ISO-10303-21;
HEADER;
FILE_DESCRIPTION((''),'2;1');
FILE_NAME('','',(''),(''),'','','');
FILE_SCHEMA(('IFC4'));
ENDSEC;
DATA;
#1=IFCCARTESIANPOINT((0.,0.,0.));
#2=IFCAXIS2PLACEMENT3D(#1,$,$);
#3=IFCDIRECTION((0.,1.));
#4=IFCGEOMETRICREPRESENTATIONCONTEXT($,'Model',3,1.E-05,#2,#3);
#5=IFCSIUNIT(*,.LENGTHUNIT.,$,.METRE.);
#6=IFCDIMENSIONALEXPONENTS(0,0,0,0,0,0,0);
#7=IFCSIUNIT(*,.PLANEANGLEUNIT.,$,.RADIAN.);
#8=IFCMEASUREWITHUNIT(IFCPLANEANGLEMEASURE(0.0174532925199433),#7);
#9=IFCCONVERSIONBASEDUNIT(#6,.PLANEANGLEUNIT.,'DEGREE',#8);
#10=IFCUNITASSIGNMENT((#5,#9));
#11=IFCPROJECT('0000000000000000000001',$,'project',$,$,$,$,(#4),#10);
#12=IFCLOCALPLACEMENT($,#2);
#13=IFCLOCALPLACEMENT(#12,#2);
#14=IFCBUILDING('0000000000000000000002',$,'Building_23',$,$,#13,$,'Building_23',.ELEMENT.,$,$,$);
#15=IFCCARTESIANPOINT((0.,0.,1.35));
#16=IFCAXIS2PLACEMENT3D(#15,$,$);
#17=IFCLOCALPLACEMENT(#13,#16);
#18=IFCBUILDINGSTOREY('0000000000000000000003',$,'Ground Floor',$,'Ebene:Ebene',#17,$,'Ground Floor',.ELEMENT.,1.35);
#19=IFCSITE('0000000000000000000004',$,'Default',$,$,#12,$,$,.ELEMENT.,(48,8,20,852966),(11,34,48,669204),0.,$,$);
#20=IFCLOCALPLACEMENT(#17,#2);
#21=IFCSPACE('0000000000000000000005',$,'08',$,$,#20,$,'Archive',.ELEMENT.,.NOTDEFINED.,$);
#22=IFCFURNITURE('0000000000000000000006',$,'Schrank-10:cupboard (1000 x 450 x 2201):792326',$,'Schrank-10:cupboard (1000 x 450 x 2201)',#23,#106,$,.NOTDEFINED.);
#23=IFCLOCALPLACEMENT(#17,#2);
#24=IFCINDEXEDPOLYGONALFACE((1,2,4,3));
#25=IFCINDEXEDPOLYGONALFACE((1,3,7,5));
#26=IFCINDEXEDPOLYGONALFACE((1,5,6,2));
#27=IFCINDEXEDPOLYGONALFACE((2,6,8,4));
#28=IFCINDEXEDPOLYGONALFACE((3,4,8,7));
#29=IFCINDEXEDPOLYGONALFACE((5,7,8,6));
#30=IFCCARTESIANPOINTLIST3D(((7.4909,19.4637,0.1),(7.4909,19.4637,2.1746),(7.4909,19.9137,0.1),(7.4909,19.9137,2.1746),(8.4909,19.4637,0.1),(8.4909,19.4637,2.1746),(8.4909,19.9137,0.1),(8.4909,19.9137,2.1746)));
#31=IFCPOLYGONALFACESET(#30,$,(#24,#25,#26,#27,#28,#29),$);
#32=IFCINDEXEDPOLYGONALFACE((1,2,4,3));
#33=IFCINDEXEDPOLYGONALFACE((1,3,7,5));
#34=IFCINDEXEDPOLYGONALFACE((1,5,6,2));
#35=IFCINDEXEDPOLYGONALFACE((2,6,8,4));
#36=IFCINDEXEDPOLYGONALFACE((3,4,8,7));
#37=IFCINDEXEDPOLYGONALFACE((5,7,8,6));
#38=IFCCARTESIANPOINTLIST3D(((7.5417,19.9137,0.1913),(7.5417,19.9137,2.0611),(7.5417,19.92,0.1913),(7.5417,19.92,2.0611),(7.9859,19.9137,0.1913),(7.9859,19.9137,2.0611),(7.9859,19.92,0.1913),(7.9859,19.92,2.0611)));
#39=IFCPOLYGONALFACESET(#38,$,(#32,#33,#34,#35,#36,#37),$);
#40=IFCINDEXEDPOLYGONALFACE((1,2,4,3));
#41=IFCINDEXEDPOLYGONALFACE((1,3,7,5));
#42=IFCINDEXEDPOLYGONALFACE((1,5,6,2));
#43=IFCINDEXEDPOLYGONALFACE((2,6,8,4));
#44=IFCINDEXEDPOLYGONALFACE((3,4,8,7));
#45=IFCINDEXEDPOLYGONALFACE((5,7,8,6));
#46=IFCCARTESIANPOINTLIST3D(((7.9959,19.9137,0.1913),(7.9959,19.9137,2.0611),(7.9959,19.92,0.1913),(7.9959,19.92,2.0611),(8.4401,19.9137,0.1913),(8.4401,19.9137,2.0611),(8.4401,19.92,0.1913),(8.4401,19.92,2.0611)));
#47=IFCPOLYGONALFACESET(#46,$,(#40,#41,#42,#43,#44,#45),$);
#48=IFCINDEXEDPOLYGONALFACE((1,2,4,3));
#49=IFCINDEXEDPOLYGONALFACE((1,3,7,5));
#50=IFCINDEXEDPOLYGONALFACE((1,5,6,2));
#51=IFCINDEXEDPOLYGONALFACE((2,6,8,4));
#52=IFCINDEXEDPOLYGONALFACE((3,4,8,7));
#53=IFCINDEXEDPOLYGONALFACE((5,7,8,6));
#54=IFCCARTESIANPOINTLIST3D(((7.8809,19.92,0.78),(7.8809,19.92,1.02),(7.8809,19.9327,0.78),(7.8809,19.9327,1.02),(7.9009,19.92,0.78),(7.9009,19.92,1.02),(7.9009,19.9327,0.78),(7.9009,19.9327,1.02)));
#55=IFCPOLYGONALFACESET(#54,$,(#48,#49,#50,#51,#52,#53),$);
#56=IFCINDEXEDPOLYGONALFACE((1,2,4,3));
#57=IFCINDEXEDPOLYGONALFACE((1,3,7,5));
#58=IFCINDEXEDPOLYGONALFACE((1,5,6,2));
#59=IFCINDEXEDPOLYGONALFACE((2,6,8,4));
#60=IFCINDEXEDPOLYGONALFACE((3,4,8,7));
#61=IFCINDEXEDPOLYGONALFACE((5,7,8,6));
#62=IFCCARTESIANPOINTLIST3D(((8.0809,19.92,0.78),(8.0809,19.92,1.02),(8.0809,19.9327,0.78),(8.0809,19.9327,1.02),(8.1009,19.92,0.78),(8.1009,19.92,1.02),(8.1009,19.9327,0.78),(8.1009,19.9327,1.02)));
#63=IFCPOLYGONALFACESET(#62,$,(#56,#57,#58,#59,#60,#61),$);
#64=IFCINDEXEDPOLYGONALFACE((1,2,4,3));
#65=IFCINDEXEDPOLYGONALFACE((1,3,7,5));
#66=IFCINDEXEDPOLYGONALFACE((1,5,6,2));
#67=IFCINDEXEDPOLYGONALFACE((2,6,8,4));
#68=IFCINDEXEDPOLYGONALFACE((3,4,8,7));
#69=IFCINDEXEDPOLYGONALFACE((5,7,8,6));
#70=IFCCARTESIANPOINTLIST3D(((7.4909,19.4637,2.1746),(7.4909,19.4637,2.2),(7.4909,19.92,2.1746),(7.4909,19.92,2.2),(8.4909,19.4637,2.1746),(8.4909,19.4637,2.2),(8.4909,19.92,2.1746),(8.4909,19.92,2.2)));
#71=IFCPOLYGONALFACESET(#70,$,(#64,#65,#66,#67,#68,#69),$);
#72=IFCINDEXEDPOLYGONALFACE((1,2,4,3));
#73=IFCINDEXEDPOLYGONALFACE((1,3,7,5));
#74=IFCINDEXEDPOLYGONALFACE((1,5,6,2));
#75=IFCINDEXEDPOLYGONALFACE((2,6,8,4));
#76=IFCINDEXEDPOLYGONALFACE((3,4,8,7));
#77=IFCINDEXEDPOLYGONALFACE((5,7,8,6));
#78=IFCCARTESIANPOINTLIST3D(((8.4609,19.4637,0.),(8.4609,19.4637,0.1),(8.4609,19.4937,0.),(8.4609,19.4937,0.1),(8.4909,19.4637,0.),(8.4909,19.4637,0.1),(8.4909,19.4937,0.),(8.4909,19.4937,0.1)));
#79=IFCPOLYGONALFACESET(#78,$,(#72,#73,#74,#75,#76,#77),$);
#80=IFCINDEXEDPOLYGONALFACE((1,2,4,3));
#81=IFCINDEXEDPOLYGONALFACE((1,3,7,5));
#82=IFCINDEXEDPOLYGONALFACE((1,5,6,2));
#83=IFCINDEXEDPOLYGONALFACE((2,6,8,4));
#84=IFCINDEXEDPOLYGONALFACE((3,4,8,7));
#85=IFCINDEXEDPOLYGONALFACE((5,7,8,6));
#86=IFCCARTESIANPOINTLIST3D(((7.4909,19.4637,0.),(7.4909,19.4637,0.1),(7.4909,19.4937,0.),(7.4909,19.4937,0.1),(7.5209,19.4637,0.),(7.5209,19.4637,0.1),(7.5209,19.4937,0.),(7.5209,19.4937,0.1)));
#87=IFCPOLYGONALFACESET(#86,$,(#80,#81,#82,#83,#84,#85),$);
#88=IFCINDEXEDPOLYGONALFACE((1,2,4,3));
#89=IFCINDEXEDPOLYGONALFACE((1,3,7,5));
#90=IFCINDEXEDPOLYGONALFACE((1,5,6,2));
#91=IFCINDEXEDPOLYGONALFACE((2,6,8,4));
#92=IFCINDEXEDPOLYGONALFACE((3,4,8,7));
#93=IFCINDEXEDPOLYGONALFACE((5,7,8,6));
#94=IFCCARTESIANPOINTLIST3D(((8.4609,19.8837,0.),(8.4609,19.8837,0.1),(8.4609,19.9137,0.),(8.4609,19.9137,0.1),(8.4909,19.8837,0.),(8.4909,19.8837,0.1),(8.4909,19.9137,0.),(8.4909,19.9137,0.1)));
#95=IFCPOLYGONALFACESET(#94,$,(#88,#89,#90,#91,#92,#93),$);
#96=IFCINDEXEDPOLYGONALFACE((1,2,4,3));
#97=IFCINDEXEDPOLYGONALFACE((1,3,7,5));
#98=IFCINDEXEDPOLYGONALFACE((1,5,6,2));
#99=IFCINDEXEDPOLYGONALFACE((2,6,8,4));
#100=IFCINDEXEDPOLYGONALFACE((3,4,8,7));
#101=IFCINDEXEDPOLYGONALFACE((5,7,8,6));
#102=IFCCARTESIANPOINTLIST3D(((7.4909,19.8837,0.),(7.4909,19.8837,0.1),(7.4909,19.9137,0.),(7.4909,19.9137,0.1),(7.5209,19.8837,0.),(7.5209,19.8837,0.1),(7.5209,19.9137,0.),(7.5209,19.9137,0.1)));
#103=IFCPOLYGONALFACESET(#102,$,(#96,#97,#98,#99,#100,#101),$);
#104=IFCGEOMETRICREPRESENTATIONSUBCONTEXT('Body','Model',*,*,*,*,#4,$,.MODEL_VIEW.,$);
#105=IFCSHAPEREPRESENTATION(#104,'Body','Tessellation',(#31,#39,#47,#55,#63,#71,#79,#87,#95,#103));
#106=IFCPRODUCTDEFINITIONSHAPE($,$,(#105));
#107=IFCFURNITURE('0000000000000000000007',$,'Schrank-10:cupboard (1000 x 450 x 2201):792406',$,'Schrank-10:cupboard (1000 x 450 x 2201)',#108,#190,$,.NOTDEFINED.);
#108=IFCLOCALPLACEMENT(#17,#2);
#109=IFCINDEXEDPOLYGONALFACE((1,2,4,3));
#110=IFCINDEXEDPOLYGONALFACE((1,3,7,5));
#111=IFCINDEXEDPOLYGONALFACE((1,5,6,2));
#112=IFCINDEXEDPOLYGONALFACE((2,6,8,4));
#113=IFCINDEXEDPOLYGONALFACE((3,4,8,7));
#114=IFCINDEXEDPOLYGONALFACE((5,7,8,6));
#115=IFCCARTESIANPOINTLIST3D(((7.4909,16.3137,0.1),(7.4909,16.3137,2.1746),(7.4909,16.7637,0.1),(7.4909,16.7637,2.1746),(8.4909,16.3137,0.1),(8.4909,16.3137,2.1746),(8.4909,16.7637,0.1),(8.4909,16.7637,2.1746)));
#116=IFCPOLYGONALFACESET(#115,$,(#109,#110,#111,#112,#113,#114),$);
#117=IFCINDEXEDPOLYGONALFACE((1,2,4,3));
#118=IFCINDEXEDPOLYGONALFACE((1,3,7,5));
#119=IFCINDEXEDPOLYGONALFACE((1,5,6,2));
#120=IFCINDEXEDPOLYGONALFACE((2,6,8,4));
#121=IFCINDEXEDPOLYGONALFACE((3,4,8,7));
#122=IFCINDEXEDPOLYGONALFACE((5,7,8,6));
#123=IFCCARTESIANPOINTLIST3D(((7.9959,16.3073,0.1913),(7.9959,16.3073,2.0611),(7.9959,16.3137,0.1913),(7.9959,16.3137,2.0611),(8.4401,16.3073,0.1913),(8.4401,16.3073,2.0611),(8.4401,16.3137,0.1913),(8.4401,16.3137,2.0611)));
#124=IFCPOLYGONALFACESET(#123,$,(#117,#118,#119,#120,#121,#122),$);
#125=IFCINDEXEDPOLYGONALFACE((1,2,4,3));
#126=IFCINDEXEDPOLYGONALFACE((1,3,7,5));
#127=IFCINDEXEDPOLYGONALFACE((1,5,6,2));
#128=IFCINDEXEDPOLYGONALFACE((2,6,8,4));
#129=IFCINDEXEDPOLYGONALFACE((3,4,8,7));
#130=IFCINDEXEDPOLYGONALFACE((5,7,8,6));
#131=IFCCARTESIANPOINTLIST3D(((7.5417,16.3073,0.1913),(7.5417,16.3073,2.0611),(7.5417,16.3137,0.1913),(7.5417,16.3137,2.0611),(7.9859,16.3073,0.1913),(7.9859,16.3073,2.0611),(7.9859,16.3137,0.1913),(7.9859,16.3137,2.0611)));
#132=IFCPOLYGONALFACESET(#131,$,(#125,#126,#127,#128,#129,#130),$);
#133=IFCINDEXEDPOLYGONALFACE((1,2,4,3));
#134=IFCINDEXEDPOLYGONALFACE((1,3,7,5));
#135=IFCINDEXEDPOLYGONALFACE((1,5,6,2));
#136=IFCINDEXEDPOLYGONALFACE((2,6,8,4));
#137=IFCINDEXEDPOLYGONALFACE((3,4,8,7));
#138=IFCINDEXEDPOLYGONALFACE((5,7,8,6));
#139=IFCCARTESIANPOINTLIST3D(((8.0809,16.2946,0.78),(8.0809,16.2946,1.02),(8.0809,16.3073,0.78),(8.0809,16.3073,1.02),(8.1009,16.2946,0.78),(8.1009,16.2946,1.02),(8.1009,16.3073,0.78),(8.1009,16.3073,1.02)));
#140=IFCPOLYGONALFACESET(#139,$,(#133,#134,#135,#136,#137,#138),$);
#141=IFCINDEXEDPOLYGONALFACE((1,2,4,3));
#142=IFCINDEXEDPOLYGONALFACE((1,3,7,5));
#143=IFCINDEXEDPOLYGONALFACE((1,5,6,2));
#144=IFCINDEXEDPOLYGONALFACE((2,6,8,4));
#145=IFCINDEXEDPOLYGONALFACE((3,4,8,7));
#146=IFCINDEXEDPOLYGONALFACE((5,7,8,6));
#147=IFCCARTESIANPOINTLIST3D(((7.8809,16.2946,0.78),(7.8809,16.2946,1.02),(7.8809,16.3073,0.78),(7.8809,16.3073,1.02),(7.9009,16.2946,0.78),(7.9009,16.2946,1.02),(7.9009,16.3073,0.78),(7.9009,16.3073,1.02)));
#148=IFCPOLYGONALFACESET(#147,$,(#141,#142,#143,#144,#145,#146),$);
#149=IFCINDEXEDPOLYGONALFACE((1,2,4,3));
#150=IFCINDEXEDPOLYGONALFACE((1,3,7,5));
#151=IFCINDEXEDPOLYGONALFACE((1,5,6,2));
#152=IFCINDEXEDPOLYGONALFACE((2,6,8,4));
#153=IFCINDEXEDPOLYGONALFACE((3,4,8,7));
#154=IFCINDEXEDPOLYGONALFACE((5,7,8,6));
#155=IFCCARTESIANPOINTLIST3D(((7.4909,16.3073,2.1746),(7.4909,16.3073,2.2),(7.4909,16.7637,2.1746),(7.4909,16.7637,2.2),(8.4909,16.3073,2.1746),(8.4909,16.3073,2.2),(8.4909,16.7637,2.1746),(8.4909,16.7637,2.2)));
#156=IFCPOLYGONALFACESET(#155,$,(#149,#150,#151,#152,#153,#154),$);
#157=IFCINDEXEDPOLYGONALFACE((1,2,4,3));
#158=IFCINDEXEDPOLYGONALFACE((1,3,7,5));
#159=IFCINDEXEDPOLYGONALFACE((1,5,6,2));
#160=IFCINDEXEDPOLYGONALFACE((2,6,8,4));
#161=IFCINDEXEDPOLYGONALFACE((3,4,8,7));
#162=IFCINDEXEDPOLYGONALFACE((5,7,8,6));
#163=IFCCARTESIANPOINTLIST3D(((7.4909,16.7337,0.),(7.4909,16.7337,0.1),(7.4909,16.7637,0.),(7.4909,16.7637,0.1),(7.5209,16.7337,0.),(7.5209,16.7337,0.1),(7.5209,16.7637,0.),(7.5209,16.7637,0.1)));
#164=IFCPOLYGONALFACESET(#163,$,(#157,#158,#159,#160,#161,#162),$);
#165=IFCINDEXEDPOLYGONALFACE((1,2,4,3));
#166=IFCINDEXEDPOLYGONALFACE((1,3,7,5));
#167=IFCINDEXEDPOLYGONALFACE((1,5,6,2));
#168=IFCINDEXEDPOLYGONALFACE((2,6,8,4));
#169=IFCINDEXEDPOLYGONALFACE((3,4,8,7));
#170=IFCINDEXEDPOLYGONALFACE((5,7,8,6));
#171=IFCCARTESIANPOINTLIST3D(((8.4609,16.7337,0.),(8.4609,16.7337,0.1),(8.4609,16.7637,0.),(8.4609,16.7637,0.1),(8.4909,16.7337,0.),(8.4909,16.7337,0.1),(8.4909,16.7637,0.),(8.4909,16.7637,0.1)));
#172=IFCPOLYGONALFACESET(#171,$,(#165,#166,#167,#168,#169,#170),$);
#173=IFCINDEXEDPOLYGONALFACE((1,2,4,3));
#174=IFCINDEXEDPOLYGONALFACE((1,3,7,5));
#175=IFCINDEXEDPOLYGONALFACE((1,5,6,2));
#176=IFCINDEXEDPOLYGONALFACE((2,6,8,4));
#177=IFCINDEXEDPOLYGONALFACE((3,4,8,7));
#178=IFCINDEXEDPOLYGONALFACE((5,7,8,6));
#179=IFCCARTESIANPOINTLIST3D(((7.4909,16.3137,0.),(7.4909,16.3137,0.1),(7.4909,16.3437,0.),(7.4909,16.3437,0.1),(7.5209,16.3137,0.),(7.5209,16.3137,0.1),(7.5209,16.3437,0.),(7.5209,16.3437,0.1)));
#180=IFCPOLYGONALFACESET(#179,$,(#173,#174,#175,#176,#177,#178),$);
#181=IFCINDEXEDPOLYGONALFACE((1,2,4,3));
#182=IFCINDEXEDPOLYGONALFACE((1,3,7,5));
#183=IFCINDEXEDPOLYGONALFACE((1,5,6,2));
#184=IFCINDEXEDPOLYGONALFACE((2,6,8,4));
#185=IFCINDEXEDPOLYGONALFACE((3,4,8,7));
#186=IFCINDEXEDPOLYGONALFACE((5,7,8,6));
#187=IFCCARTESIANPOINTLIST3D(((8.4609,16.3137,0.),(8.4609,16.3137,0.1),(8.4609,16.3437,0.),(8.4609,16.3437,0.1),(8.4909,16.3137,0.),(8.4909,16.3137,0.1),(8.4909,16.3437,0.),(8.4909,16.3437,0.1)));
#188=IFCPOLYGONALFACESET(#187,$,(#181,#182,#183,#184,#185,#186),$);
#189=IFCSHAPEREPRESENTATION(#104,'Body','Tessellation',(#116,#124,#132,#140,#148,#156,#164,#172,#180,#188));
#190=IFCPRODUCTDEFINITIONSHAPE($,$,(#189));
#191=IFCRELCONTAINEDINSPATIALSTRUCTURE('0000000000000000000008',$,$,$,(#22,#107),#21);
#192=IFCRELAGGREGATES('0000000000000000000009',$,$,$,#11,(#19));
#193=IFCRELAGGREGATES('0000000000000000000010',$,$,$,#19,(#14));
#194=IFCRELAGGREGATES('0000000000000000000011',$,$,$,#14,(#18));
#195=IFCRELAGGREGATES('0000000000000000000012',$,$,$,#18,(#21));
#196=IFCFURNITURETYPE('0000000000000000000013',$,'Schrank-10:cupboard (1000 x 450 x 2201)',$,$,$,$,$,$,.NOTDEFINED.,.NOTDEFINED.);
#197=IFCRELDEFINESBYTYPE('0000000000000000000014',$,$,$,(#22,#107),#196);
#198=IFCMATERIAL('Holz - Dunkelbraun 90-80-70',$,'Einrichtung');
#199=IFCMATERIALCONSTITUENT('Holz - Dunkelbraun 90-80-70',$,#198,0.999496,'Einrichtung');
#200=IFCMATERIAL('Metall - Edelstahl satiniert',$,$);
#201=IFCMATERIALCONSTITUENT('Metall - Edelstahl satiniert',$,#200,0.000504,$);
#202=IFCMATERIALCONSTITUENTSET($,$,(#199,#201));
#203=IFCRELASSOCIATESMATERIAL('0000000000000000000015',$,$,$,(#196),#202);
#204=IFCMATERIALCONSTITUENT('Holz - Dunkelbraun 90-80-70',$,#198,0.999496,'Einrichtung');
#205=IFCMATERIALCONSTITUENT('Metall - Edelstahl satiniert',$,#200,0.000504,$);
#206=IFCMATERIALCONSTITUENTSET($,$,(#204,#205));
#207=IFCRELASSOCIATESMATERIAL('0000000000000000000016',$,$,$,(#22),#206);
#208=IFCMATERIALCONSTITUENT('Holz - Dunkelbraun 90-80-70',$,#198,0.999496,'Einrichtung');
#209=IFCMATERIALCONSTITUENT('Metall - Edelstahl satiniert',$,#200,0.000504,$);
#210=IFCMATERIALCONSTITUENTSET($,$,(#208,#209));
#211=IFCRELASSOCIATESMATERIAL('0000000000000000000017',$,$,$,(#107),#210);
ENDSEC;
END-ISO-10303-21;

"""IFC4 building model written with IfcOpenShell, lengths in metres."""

from ifc_helpers import new_model, entity, si_unit, converted_unit, direction, frame, origin, place, context, subcontext, project, spatial, indexed_curve, outline, extrude, source, transform, mapped, material, constituent, constituent_set, type_object, type_shapes, element, save


model = new_model("IFC4")

# Units and contexts
model_context = context("Model", 3, precision=1e-05, world=origin(), true_north=direction((0.0, 1.0)))
body_context = subcontext(model_context, "Body", "Model", "MODEL_VIEW")
ifc_project = project(units=[si_unit("LENGTHUNIT", "METRE"), converted_unit("PLANEANGLEUNIT", "DEGREE", entity("IfcPlaneAngleMeasure", 0.0174532925199433), si_unit("PLANEANGLEUNIT", "RADIAN"), dimensions=[0, 0, 0, 0, 0, 0, 0])], contexts=[model_context])

# Site, building, storey
site_placement = place(None, origin())
site = spatial("IfcSite", under=ifc_project, at=site_placement, Name="Default", CompositionType="ELEMENT", RefLatitude=(48, 8, 20, 852966), RefLongitude=(11, 34, 48, 669204), RefElevation=0.0)
building_placement = place(site_placement, origin())
building = spatial("IfcBuilding", under=site, at=building_placement, Name="Building_23", LongName="Building_23", CompositionType="ELEMENT")
storey_placement = place(building_placement, frame((0.0, 0.0, 1.35)))
storey = spatial("IfcBuildingStorey", under=building, at=storey_placement, Name="Ground Floor", ObjectType="Ebene:Ebene", LongName="Ground Floor", CompositionType="ELEMENT", Elevation=1.35)

# Shared definitions
space_placement = place(storey_placement, origin())
space = spatial("IfcSpace", under=storey, at=space_placement, Name="08", LongName="Archive", CompositionType="ELEMENT", PredefinedType="NOTDEFINED")

# Furniture
ifc_material_1 = material(Name="Holz - Dunkelbraun 90-80-70", Category="Einrichtung")
ifc_material_2 = material(Name="Metall - Edelstahl satiniert")
ifc_constituent_1 = constituent(ifc_material_1, Name="Holz - Dunkelbraun 90-80-70", Category="Einrichtung", fraction=0.999496)
ifc_constituent_2 = constituent(ifc_material_2, Name="Metall - Edelstahl satiniert", fraction=0.000504)
ifc_constituent_set_1 = constituent_set(constituents=[ifc_constituent_1, ifc_constituent_2])
furniture_type = type_object("IfcFurnitureType", Name="Schrank-10:cupboard (1000 x 450 x 2201)", AssemblyPlace="NOTDEFINED", PredefinedType="NOTDEFINED", material=ifc_constituent_set_1)
shared_shape_1 = source(origin(), body_context, "Body", "SweptSolid", [
    extrude(outline(indexed_curve([(-0.225, -0.5), (0.225, -0.5), (0.225, 0.5), (-0.225, 0.5), (-0.225, -0.5)], self_intersect=False)), frame((-0.2692, -0.3632, 0.1), z_axis=(0.0, 0.0, 1.0), x_axis=(0.0, 1.0, 0.0)), (0.0, 0.0, 1.0), 2.0746),
    extrude(outline(indexed_curve([(-0.0032, -0.2221), (0.0032, -0.2221), (0.0032, 0.2221), (-0.0032, 0.2221), (-0.0032, -0.2221)], self_intersect=False)), frame((-0.0421, -0.5913, 0.1913), z_axis=(0.0, 0.0, 1.0), x_axis=(0.0, 1.0, 0.0)), (0.0, 0.0, 1.0), 1.8698),
    extrude(outline(indexed_curve([(-0.0032, -0.2221), (0.0032, -0.2221), (0.0032, 0.2221), (-0.0032, 0.2221), (-0.0032, -0.2221)], self_intersect=False)), frame((-0.4963, -0.5913, 0.1913), z_axis=(0.0, 0.0, 1.0), x_axis=(0.0, 1.0, 0.0)), (0.0, 0.0, 1.0), 1.8698),
    extrude(outline(indexed_curve([(-0.0063, -0.01), (0.0063, -0.01), (0.0063, 0.01), (-0.0063, 0.01), (-0.0063, -0.01)], self_intersect=False)), frame((-0.1692, -0.6009, 0.78), z_axis=(0.0, 0.0, 1.0), x_axis=(0.0, 1.0, 0.0)), (0.0, 0.0, 1.0), 0.24),
    extrude(outline(indexed_curve([(-0.0063, -0.01), (0.0063, -0.01), (0.0063, 0.01), (-0.0063, 0.01), (-0.0063, -0.01)], self_intersect=False)), frame((-0.3692, -0.6009, 0.78), z_axis=(0.0, 0.0, 1.0), x_axis=(0.0, 1.0, 0.0)), (0.0, 0.0, 1.0), 0.24),
    extrude(outline(indexed_curve([(-0.5, -0.2282), (0.5, -0.2282), (0.5, 0.2282), (-0.5, 0.2282), (-0.5, -0.2282)], self_intersect=False)), frame((-0.2692, -0.3663, 2.1746), z_axis=(0.0, 0.0, 1.0), x_axis=(-1.0, 0.0, 0.0)), (0.0, 0.0, 1.0), 0.0254),
    extrude(outline(indexed_curve([(-0.015, -0.015), (0.015, -0.015), (0.015, 0.015), (-0.015, 0.015), (-0.015, -0.015)], self_intersect=False)), frame((-0.7542, -0.1532, 0.0), z_axis=(0.0, 0.0, 1.0), x_axis=(-1.0, 0.0, 0.0)), (0.0, 0.0, 1.0), 0.1),
    extrude(outline(indexed_curve([(-0.015, -0.015), (0.015, -0.015), (0.015, 0.015), (-0.015, 0.015), (-0.015, -0.015)], self_intersect=False)), frame((0.2158, -0.1532, 0.0), z_axis=(0.0, 0.0, 1.0), x_axis=(0.0, -1.0, 0.0)), (0.0, 0.0, 1.0), 0.1),
    extrude(outline(indexed_curve([(-0.015, -0.015), (0.015, -0.015), (0.015, 0.015), (-0.015, 0.015), (-0.015, -0.015)], self_intersect=False)), frame((-0.7542, -0.5732, 0.0), z_axis=(0.0, 0.0, 1.0), x_axis=(0.0, 1.0, 0.0)), (0.0, 0.0, 1.0), 0.1),
    extrude(outline(indexed_curve([(-0.015, -0.015), (0.015, -0.015), (0.015, 0.015), (-0.015, 0.015), (-0.015, -0.015)], self_intersect=False)), frame((0.2158, -0.5732, 0.0)), (0.0, 0.0, 1.0), 0.1),
])
type_shapes(furniture_type, [shared_shape_1])
ifc_constituent_3 = constituent(ifc_material_1, Name="Holz - Dunkelbraun 90-80-70", Category="Einrichtung", fraction=0.999496)
ifc_constituent_4 = constituent(ifc_material_2, Name="Metall - Edelstahl satiniert", fraction=0.000504)
ifc_constituent_set_2 = constituent_set(constituents=[ifc_constituent_3, ifc_constituent_4])
furniture_1_placement = place(space_placement, frame((7.7217, 19.3255, 0.0), z_axis=(0.0, 0.0, 1.0), x_axis=(-1.0, 0.0, 0.0)))
element("IfcFurniture", 1, at=furniture_1_placement, inside=space, type_object=furniture_type, material=ifc_constituent_set_2, Name="Schrank-10:cupboard (1000 x 450 x 2201):792326", ObjectType="Schrank-10:cupboard (1000 x 450 x 2201)", PredefinedType="NOTDEFINED", context=body_context, shape_type="MappedRepresentation", body=[
    mapped(shared_shape_1, transform((0.0, 0.0, 0.0), scale=1.0)),
])
ifc_constituent_5 = constituent(ifc_material_1, Name="Holz - Dunkelbraun 90-80-70", Category="Einrichtung", fraction=0.999496)
ifc_constituent_6 = constituent(ifc_material_2, Name="Metall - Edelstahl satiniert", fraction=0.000504)
ifc_constituent_set_3 = constituent_set(constituents=[ifc_constituent_5, ifc_constituent_6])
furniture_2_placement = place(space_placement, frame((8.2601, 16.9019, 0.0)))
element("IfcFurniture", 2, at=furniture_2_placement, inside=space, type_object=furniture_type, material=ifc_constituent_set_3, Name="Schrank-10:cupboard (1000 x 450 x 2201):792406", ObjectType="Schrank-10:cupboard (1000 x 450 x 2201)", PredefinedType="NOTDEFINED", context=body_context, shape_type="MappedRepresentation", body=[
    mapped(shared_shape_1, transform((0.0, 0.0, 0.0), scale=1.0)),
])

save(model, "model.ifc")
